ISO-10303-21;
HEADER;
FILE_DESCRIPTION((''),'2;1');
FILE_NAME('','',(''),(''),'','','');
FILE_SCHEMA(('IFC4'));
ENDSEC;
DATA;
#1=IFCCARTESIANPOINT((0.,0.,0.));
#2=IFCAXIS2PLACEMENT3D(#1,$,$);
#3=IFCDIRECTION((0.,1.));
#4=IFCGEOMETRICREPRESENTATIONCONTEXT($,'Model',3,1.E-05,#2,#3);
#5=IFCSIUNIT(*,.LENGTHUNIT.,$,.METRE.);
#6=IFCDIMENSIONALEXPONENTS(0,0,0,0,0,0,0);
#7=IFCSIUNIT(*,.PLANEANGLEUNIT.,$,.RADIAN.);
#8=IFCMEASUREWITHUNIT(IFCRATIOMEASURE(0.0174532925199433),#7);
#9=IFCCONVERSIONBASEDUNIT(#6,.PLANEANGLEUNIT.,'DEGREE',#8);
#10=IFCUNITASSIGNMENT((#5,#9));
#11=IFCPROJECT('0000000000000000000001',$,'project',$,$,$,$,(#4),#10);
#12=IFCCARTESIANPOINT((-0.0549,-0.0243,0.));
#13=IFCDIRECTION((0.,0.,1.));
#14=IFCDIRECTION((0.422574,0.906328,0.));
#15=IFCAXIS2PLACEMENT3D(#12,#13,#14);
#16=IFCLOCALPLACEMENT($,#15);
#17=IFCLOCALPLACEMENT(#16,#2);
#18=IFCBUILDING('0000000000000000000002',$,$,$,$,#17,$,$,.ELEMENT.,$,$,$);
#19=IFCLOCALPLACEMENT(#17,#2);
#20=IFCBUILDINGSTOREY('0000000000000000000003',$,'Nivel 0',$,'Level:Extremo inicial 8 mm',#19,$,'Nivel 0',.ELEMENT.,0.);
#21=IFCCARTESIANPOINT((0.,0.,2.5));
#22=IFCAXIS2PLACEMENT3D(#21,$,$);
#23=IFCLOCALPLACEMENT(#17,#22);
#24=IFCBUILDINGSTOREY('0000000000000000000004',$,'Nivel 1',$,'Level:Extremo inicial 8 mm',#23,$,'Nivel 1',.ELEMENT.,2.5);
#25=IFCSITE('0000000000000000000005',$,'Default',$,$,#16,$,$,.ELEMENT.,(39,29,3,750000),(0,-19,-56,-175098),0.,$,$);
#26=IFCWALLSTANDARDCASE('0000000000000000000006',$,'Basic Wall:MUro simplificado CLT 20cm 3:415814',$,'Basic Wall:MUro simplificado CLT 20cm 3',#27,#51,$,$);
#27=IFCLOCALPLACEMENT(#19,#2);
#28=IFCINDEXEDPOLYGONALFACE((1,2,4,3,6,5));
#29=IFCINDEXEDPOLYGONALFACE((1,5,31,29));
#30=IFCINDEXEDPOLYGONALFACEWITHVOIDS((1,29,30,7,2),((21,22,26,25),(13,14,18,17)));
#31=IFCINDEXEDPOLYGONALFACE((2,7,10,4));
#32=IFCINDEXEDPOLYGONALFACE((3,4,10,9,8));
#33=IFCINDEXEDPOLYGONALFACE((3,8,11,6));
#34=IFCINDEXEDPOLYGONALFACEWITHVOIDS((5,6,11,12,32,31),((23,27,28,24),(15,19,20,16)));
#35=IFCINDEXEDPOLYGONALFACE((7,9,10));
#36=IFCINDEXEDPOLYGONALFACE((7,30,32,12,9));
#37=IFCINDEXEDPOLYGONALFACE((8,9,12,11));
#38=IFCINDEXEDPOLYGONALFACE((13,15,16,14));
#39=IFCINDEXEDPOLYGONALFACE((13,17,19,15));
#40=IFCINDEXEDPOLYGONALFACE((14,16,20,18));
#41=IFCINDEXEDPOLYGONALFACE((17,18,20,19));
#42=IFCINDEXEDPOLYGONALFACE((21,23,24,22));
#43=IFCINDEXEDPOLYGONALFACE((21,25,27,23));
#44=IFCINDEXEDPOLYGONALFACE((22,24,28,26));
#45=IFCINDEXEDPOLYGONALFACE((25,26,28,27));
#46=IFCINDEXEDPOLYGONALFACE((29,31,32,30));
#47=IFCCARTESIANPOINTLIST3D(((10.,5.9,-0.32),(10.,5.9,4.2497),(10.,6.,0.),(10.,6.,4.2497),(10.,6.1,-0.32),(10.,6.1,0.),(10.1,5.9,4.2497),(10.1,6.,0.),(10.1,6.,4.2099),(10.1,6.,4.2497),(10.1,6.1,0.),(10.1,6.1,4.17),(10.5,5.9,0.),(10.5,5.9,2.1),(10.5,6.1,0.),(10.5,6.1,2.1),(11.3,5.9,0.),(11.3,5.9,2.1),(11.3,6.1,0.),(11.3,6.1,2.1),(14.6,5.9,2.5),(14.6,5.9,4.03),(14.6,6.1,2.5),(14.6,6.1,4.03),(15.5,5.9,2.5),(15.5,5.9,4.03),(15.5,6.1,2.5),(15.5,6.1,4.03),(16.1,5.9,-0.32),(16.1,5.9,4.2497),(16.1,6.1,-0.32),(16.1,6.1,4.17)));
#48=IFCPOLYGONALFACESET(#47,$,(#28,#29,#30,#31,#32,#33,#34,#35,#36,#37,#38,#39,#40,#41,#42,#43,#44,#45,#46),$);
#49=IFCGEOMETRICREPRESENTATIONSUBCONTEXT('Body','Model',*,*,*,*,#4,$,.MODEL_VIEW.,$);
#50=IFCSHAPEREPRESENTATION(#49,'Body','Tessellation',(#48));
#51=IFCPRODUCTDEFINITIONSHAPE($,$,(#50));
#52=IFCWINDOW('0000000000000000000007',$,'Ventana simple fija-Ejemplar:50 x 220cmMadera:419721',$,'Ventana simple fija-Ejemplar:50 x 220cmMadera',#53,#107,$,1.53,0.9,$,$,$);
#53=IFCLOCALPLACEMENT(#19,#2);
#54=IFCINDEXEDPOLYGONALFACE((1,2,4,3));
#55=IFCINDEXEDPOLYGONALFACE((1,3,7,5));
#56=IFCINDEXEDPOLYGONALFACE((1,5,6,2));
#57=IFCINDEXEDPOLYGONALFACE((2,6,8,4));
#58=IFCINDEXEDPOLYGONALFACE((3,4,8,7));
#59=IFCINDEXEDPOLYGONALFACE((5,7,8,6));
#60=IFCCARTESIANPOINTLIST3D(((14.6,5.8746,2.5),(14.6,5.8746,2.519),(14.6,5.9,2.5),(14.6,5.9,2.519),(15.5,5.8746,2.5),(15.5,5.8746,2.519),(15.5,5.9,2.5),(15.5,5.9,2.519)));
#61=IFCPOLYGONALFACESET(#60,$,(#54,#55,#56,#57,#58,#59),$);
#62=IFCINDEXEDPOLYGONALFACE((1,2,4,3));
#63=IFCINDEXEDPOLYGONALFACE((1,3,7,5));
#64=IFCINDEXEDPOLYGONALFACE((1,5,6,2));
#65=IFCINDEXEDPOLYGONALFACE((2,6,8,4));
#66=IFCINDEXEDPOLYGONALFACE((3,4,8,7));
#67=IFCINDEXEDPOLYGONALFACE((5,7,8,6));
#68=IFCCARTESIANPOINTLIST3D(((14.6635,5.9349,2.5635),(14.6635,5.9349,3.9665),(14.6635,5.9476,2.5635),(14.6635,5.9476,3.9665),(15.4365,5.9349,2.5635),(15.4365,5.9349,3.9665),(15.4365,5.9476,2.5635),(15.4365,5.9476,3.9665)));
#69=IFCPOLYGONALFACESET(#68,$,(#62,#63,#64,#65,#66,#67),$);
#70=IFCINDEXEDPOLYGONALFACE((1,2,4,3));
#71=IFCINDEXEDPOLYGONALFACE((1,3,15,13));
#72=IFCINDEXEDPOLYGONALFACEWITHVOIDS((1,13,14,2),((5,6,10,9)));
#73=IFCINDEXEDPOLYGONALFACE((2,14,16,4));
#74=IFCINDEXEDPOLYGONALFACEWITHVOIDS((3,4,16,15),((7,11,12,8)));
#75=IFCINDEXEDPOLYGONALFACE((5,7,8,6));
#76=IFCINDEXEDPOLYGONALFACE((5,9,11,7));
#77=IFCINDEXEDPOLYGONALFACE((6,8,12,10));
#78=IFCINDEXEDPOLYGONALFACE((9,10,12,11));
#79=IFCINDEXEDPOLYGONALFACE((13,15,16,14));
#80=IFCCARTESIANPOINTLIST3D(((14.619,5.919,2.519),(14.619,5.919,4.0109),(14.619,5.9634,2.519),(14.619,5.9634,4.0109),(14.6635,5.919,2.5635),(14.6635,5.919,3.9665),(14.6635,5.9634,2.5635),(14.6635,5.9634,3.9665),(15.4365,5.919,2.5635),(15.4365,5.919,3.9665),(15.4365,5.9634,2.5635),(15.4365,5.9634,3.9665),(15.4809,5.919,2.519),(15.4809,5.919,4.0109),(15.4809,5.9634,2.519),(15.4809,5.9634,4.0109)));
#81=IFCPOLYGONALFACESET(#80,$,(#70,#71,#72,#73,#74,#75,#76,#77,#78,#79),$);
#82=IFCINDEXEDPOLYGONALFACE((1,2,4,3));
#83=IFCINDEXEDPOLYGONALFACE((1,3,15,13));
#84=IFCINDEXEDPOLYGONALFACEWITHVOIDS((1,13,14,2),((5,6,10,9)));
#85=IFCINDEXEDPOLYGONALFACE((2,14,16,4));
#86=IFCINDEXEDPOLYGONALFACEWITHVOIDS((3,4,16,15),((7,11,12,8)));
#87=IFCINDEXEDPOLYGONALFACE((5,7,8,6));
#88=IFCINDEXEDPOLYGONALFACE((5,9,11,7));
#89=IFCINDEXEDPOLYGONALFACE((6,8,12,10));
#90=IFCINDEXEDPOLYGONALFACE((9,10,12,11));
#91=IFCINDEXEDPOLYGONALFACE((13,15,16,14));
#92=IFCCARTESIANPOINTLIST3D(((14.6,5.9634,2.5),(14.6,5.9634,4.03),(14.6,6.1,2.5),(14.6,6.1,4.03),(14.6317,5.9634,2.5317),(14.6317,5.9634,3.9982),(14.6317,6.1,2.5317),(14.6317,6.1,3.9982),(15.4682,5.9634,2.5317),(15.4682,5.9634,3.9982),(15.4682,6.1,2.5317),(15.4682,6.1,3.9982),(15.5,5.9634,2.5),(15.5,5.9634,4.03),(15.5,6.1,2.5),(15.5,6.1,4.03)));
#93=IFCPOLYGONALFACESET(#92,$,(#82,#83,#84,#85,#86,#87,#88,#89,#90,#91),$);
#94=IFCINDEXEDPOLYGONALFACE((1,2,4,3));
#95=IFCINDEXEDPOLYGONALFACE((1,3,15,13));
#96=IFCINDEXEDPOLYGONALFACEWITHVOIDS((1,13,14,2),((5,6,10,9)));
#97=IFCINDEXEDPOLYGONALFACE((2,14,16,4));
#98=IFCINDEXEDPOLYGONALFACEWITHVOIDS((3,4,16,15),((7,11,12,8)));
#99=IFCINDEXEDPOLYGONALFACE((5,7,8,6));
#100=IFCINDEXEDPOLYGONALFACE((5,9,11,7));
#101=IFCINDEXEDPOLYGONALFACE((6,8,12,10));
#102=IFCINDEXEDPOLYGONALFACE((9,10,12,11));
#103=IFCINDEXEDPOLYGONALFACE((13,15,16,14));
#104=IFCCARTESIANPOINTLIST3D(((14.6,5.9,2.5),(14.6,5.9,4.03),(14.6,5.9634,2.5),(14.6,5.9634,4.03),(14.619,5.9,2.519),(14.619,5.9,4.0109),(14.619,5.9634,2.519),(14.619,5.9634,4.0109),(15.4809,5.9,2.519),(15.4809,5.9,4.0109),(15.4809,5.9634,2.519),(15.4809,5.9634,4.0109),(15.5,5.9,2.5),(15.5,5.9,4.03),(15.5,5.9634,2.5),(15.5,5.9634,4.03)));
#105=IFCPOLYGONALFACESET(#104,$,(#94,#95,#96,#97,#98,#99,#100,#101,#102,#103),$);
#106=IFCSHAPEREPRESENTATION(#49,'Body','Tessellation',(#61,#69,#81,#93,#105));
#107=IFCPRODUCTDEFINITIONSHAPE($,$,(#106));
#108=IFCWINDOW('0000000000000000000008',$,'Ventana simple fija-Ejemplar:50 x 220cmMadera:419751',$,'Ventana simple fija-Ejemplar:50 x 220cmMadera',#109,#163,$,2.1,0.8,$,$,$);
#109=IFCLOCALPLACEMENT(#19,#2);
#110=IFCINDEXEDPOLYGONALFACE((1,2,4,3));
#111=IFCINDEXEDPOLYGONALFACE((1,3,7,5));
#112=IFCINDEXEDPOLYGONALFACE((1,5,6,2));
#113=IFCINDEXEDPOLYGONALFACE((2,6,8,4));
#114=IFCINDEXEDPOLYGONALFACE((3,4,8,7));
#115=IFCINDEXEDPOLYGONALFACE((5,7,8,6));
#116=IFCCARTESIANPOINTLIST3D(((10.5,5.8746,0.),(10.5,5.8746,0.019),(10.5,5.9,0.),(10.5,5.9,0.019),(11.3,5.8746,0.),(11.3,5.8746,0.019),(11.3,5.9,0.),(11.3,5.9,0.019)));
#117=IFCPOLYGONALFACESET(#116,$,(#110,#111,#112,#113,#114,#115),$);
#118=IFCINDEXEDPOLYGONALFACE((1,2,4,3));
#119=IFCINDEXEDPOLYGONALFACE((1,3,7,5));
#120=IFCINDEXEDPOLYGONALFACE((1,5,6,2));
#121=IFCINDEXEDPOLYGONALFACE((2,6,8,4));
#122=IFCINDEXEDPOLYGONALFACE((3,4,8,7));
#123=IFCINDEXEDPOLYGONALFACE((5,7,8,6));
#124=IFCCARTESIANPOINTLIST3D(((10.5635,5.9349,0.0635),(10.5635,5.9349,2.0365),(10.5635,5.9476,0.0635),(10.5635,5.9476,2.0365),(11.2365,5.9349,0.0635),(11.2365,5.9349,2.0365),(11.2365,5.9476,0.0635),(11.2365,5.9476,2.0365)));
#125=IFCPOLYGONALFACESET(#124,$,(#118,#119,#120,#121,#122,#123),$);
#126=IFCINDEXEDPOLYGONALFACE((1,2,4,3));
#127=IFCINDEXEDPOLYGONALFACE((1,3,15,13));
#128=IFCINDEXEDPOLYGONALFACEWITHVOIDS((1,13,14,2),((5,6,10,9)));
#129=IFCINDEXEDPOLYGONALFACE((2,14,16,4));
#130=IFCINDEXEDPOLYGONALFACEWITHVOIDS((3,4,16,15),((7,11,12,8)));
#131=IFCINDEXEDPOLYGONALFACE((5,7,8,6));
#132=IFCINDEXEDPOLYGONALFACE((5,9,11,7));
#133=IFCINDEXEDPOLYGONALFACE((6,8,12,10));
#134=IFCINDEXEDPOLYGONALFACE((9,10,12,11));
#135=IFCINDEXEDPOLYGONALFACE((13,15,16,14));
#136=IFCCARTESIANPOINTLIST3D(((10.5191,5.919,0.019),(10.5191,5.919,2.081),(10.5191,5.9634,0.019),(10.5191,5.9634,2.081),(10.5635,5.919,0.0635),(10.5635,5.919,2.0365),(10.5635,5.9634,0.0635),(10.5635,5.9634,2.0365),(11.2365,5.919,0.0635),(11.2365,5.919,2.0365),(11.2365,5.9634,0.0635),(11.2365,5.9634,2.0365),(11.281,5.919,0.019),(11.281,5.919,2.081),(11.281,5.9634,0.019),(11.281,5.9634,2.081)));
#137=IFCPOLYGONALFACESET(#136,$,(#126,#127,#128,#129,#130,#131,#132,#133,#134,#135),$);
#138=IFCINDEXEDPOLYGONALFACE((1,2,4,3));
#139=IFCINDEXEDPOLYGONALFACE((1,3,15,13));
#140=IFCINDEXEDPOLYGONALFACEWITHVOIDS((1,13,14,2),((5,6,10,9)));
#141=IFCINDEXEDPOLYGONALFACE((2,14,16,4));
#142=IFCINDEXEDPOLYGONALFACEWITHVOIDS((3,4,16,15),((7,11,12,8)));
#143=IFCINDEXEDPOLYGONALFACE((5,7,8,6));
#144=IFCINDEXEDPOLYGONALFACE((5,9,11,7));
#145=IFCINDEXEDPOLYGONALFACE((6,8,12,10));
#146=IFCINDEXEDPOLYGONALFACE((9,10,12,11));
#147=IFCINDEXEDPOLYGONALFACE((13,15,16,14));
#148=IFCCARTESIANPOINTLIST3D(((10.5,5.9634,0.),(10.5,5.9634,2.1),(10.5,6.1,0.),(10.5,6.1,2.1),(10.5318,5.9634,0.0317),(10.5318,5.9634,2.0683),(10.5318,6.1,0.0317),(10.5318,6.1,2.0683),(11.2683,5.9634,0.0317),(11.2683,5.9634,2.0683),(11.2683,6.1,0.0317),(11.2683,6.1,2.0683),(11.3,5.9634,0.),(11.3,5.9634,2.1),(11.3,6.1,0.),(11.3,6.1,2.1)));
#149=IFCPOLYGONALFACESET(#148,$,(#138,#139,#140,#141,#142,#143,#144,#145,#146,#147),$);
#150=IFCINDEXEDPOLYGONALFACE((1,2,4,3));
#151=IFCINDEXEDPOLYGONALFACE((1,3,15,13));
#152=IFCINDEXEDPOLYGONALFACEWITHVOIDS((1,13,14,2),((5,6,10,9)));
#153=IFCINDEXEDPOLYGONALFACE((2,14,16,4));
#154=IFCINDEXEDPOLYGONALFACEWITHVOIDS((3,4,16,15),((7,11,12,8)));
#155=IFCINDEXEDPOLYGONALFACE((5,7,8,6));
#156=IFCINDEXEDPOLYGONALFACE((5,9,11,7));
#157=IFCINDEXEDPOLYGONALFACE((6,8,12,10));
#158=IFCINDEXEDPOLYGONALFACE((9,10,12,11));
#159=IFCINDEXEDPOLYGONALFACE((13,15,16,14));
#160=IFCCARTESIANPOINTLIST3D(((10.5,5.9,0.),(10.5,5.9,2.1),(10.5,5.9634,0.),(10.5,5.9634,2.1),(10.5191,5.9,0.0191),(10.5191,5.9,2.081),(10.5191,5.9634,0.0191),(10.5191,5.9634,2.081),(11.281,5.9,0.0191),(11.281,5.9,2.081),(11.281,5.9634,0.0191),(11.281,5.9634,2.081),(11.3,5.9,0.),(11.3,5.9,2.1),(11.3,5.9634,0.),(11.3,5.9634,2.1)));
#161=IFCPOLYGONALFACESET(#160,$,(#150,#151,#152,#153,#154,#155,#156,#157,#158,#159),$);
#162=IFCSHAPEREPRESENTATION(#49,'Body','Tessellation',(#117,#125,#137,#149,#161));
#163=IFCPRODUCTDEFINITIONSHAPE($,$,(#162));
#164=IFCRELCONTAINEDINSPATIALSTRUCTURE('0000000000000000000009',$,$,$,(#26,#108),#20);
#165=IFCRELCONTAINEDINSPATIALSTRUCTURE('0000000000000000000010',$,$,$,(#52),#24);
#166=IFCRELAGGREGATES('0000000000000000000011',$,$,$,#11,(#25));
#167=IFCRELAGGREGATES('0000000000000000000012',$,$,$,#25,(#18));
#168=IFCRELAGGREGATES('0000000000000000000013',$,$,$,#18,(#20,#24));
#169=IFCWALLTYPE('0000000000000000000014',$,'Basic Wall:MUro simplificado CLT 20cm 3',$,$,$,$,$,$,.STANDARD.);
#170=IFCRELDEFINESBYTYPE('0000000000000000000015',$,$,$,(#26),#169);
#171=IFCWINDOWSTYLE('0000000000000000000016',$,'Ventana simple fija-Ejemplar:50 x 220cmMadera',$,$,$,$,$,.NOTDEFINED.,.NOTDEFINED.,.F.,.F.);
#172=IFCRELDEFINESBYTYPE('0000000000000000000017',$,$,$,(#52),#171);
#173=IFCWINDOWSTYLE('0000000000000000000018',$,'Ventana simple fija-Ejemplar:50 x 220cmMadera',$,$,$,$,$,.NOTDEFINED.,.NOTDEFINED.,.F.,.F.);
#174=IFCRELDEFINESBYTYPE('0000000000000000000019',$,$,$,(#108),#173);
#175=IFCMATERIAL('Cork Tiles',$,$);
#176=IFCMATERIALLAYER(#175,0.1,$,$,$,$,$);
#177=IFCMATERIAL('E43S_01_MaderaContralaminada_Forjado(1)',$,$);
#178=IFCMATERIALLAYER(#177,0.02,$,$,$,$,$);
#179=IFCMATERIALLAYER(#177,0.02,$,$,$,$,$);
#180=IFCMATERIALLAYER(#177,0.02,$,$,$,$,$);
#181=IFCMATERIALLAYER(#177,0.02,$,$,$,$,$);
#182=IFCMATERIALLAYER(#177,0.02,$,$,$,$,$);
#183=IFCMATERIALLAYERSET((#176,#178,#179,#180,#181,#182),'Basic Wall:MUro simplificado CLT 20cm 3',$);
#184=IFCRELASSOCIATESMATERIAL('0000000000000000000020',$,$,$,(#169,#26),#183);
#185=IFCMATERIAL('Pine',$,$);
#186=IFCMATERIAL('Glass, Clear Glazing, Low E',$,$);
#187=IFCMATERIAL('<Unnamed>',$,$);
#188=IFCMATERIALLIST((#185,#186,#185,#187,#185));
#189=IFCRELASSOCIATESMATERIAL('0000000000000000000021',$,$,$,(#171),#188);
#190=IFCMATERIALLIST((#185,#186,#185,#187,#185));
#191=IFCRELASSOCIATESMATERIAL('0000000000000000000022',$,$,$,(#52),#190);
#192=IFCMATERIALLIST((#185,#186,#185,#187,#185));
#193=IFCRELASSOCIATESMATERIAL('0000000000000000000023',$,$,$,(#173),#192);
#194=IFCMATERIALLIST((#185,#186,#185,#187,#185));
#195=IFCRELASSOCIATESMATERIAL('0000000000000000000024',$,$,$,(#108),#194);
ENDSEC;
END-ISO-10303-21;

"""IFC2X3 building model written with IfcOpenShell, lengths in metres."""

from ifc_helpers import new_model, entity, si_unit, converted_unit, direction, frame, frame_2d, origin, origin_2d_with_axis, place, context, subcontext, project, spatial, polyline, rectangle, outline, extrude, clip, bounded_halfspace, source, transform, mapped, material, material_list, layer, layer_set, layer_usage, type_object, type_shapes, element, fill, save


model = new_model("IFC2X3")

# Units and contexts
model_context = context("Model", 3, precision=1e-05, world=origin(), true_north=direction((0.0, 1.0)))
body_context = subcontext(model_context, "Body", "Model", "MODEL_VIEW")
ifc_project = project(units=[si_unit("LENGTHUNIT", "METRE"), converted_unit("PLANEANGLEUNIT", "DEGREE", entity("IfcRatioMeasure", 0.0174532925199433), si_unit("PLANEANGLEUNIT", "RADIAN"), dimensions=[0, 0, 0, 0, 0, 0, 0])], contexts=[model_context])

# Site, building, storey
site_placement = place(None, frame((-0.0549, -0.0243, 0.0), z_axis=(0.0, 0.0, 1.0), x_axis=(0.422574, 0.906328, 0.0)))
site = spatial("IfcSite", under=ifc_project, at=site_placement, Name="Default", CompositionType="ELEMENT", RefLatitude=(39, 29, 3, 750000), RefLongitude=(0, -19, -56, -175098), RefElevation=0.0)
building_placement = place(site_placement, origin())
building = spatial("IfcBuilding", under=site, at=building_placement, CompositionType="ELEMENT")
storey_1_placement = place(building_placement, origin())
storey_1 = spatial("IfcBuildingStorey", under=building, at=storey_1_placement, Name="Nivel 0", ObjectType="Level:Extremo inicial 8 mm", LongName="Nivel 0", CompositionType="ELEMENT", Elevation=0.0)

# Shared definitions
ifc_material_1 = material(Name="Cork Tiles")

# Shared definitions
ifc_layer_1 = layer(ifc_material_1, 0.1)
ifc_material_2 = material(Name="E43S_01_MaderaContralaminada_Forjado(1)")
ifc_layer_2 = layer(ifc_material_2, 0.02)
ifc_layer_3 = layer(ifc_material_2, 0.02)
ifc_layer_4 = layer(ifc_material_2, 0.02)
ifc_layer_5 = layer(ifc_material_2, 0.02)
ifc_layer_6 = layer(ifc_material_2, 0.02)
ifc_layer_set_1 = layer_set([ifc_layer_1, ifc_layer_2, ifc_layer_3, ifc_layer_4, ifc_layer_5, ifc_layer_6], Name="Basic Wall:MUro simplificado CLT 20cm 3")
wall_type = type_object("IfcWallType", Name="Basic Wall:MUro simplificado CLT 20cm 3", PredefinedType="STANDARD", material=ifc_layer_set_1)
ifc_material_3 = material(Name="Pine")
ifc_material_4 = material(Name="Glass, Clear Glazing, Low E")
ifc_material_5 = material(Name="<Unnamed>")

# Shared definitions
storey_2_placement = place(building_placement, frame((0.0, 0.0, 2.5)))
storey_2 = spatial("IfcBuildingStorey", under=building, at=storey_2_placement, Name="Nivel 1", ObjectType="Level:Extremo inicial 8 mm", LongName="Nivel 1", CompositionType="ELEMENT", Elevation=2.5)

# Wall, openings, windows
ifc_layer_usage_1 = layer_usage(ifc_layer_set_1, "AXIS2", "NEGATIVE", 0.1)
wall_1_placement = place(storey_1_placement, frame((10.0, 6.0, -0.32)))
wall_1 = element("IfcWallStandardCase", 1, at=wall_1_placement, inside=storey_1, type_object=wall_type, material=ifc_layer_usage_1, Name="Basic Wall:MUro simplificado CLT 20cm 3:415814", ObjectType="Basic Wall:MUro simplificado CLT 20cm 3", context=body_context, shape_type="Clipping", body=[
    clip(clip(extrude(rectangle(XDim=6.1, YDim=0.2, at=frame_2d((3.05, 0.0), x_axis=(-1.0, 0.0))), origin(), (0.0, 0.0, 1.0), 4.5697), bounded_halfspace(frame((0.1, -0.1, 4.5697), z_axis=(0.0, 0.370288, 0.928917), x_axis=(-1.0, 0.0, 0.0)), False, frame((0.1, -0.1, 4.5697)), polyline([(0.0, 0.0), (5.8, 0.0), (6.0, 0.0), (6.0, 0.2), (0.0, 0.2), (0.0, 0.0)]))), bounded_halfspace(frame((0.0, 0.0, 0.32)), False, frame((0.0, 0.0, 0.32)), polyline([(0.0, 0.0), (0.1, 0.0), (0.1, 0.1), (0.0, 0.1), (0.0, 0.0)]))),
])
opening_1_placement = place(wall_1_placement, frame((1.3, 0.1, 0.32)))
opening_1 = element("IfcOpeningElement", 2, at=opening_1_placement, cuts=wall_1, ObjectType="Opening", context=body_context, shape_type="SweptSolid", body=[
    extrude(rectangle(XDim=2.1, YDim=0.8, at=frame_2d((1.05, 0.4), x_axis=(-1.0, 0.0))), frame((0.0, 0.0, 0.0), z_axis=(0.0, -1.0, 0.0), x_axis=(0.0, 0.0, 1.0)), (0.0, 0.0, 1.0), 0.2),
])
opening_2_placement = place(wall_1_placement, frame((5.5, 0.1, 2.82)))
opening_2 = element("IfcOpeningElement", 3, at=opening_2_placement, cuts=wall_1, ObjectType="Opening", context=body_context, shape_type="SweptSolid", body=[
    extrude(rectangle(XDim=1.53, YDim=0.9, at=frame_2d((0.765, 0.45), x_axis=(-1.0, 0.0))), frame((0.0, 0.0, 0.0), z_axis=(0.0, -1.0, 0.0), x_axis=(0.0, 0.0, 1.0)), (0.0, 0.0, 1.0), 0.2),
])
ifc_material_list_1 = material_list([ifc_material_3, ifc_material_4, ifc_material_3, ifc_material_5, ifc_material_3])
ifc_material_list_2 = material_list([ifc_material_3, ifc_material_4, ifc_material_3, ifc_material_5, ifc_material_3])
window_style_1 = type_object("IfcWindowStyle", Name="Ventana simple fija-Ejemplar:50 x 220cmMadera", ConstructionType="NOTDEFINED", OperationType="NOTDEFINED", ParameterTakesPrecedence=False, Sizeable=False, material=ifc_material_list_2)
shared_shape_1 = source(origin(), body_context, "Body", "SweptSolid", [
    extrude(rectangle(XDim=0.0254, YDim=0.9, at=frame_2d((0.0, 0.0), x_axis=(1.0, 0.0))), frame((0.45, 0.2127, 0.0), z_axis=(0.0, 0.0, 1.0), x_axis=(0.0, -1.0, 0.0)), (0.0, 0.0, 1.0), 0.019),
    extrude(rectangle(XDim=0.0127, YDim=0.773, at=frame_2d((0.0, 0.0), x_axis=(1.0, 0.0))), frame((0.45, 0.1588, 0.0635), z_axis=(0.0, 0.0, 1.0), x_axis=(0.0, 1.0, 0.0)), (0.0, 0.0, 1.0), 1.403),
    extrude(outline(polyline([(-0.431, -0.7459), (0.431, -0.7459), (0.431, 0.7459), (-0.431, 0.7459), (-0.431, -0.7459)]), holes=[polyline([(-0.3865, -0.7015), (-0.3865, 0.7015), (0.3865, 0.7015), (0.3865, -0.7015), (-0.3865, -0.7015)])]), frame((0.45, 0.1366, 0.765), z_axis=(0.0, 1.0, 0.0), x_axis=(1.0, 0.0, 0.0)), (0.0, 0.0, 1.0), 0.0445),
    extrude(outline(polyline([(-0.45, -0.765), (0.45, -0.765), (0.45, 0.765), (-0.45, 0.765), (-0.45, -0.765)]), holes=[polyline([(-0.4183, -0.7332), (-0.4183, 0.7332), (0.4183, 0.7332), (0.4183, -0.7332), (-0.4183, -0.7332)])]), frame((0.45, 0.0, 0.765), z_axis=(0.0, 1.0, 0.0), x_axis=(1.0, 0.0, 0.0)), (0.0, 0.0, 1.0), 0.1366),
    extrude(outline(polyline([(-0.765, -0.45), (0.765, -0.45), (0.765, 0.45), (-0.765, 0.45), (-0.765, -0.45)]), holes=[polyline([(-0.7459, -0.431), (-0.7459, 0.431), (0.7459, 0.431), (0.7459, -0.431), (-0.7459, -0.431)])]), frame((0.45, 0.1366, 0.765), z_axis=(0.0, 1.0, 0.0), x_axis=(0.0, 0.0, -1.0)), (0.0, 0.0, 1.0), 0.0635),
])
type_shapes(window_style_1, [shared_shape_1])
window_1_placement = place(opening_2_placement, frame((0.0, 0.0, 0.0), z_axis=(0.0, 0.0, 1.0), x_axis=(-1.0, 0.0, 0.0)))
window_1 = element("IfcWindow", 4, at=window_1_placement, inside=storey_2, type_object=window_style_1, material=ifc_material_list_1, Name="Ventana simple fija-Ejemplar:50 x 220cmMadera:419721", ObjectType="Ventana simple fija-Ejemplar:50 x 220cmMadera", OverallHeight=1.53, OverallWidth=0.9, context=body_context, shape_type="MappedRepresentation", body=[
    mapped(shared_shape_1, transform((0.0, 0.0, 0.0), scale=1.0)),
])
fill(opening_2, window_1)
ifc_material_list_3 = material_list([ifc_material_3, ifc_material_4, ifc_material_3, ifc_material_5, ifc_material_3])
ifc_material_list_4 = material_list([ifc_material_3, ifc_material_4, ifc_material_3, ifc_material_5, ifc_material_3])
window_style_2 = type_object("IfcWindowStyle", Name="Ventana simple fija-Ejemplar:50 x 220cmMadera", ConstructionType="NOTDEFINED", OperationType="NOTDEFINED", ParameterTakesPrecedence=False, Sizeable=False, material=ifc_material_list_4)
shared_shape_2 = source(origin(), body_context, "Body", "SweptSolid", [
    extrude(rectangle(XDim=0.8, YDim=0.0254, at=origin_2d_with_axis()), frame((0.4762, 0.2127, 0.0), z_axis=(0.0, 0.0, 1.0), x_axis=(-1.0, 0.0, 0.0)), (0.0, 0.0, 1.0), 0.019),
    extrude(rectangle(XDim=0.673, YDim=0.0127, at=frame_2d((0.0, 0.0), x_axis=(1.0, 0.0))), frame((0.4762, 0.1588, 0.0635)), (0.0, 0.0, 1.0), 1.973),
    extrude(outline(polyline([(-0.381, -1.031), (0.381, -1.031), (0.381, 1.031), (-0.381, 1.031), (-0.381, -1.031)]), holes=[polyline([(-0.3365, -0.9865), (-0.3365, 0.9865), (0.3365, 0.9865), (0.3365, -0.9865), (-0.3365, -0.9865)])]), frame((0.4762, 0.181, 1.05), z_axis=(0.0, -1.0, 0.0), x_axis=(-1.0, 0.0, 0.0)), (0.0, 0.0, 1.0), 0.0445),
    extrude(outline(polyline([(-0.4, -1.05), (0.4, -1.05), (0.4, 1.05), (-0.4, 1.05), (-0.4, -1.05)]), holes=[polyline([(-0.3683, -1.0183), (-0.3683, 1.0183), (0.3682, 1.0183), (0.3682, -1.0183), (-0.3683, -1.0183)])]), frame((0.4762, 0.1366, 1.05), z_axis=(0.0, -1.0, 0.0), x_axis=(-1.0, 0.0, 0.0)), (0.0, 0.0, 1.0), 0.1366),
    extrude(outline(polyline([(-1.05, -0.4), (1.05, -0.4), (1.05, 0.4), (-1.05, 0.4), (-1.05, -0.4)]), holes=[polyline([(-1.031, -0.3809), (-1.031, 0.381), (1.031, 0.381), (1.031, -0.3809), (-1.031, -0.3809)])]), frame((0.4762, 0.2, 1.05), z_axis=(0.0, -1.0, 0.0), x_axis=(0.0, 0.0, -1.0)), (0.0, 0.0, 1.0), 0.0635),
])
type_shapes(window_style_2, [shared_shape_2])
window_2_placement = place(opening_1_placement, frame((0.0762, 0.0, 0.0), z_axis=(0.0, 0.0, 1.0), x_axis=(-1.0, 0.0, 0.0)))
window_2 = element("IfcWindow", 5, at=window_2_placement, inside=storey_1, type_object=window_style_2, material=ifc_material_list_3, Name="Ventana simple fija-Ejemplar:50 x 220cmMadera:419751", ObjectType="Ventana simple fija-Ejemplar:50 x 220cmMadera", OverallHeight=2.1, OverallWidth=0.8, context=body_context, shape_type="MappedRepresentation", body=[
    mapped(shared_shape_2, transform((0.0, 0.0, 0.0), scale=1.0)),
])
fill(opening_1, window_2)

save(model, "model.ifc")
